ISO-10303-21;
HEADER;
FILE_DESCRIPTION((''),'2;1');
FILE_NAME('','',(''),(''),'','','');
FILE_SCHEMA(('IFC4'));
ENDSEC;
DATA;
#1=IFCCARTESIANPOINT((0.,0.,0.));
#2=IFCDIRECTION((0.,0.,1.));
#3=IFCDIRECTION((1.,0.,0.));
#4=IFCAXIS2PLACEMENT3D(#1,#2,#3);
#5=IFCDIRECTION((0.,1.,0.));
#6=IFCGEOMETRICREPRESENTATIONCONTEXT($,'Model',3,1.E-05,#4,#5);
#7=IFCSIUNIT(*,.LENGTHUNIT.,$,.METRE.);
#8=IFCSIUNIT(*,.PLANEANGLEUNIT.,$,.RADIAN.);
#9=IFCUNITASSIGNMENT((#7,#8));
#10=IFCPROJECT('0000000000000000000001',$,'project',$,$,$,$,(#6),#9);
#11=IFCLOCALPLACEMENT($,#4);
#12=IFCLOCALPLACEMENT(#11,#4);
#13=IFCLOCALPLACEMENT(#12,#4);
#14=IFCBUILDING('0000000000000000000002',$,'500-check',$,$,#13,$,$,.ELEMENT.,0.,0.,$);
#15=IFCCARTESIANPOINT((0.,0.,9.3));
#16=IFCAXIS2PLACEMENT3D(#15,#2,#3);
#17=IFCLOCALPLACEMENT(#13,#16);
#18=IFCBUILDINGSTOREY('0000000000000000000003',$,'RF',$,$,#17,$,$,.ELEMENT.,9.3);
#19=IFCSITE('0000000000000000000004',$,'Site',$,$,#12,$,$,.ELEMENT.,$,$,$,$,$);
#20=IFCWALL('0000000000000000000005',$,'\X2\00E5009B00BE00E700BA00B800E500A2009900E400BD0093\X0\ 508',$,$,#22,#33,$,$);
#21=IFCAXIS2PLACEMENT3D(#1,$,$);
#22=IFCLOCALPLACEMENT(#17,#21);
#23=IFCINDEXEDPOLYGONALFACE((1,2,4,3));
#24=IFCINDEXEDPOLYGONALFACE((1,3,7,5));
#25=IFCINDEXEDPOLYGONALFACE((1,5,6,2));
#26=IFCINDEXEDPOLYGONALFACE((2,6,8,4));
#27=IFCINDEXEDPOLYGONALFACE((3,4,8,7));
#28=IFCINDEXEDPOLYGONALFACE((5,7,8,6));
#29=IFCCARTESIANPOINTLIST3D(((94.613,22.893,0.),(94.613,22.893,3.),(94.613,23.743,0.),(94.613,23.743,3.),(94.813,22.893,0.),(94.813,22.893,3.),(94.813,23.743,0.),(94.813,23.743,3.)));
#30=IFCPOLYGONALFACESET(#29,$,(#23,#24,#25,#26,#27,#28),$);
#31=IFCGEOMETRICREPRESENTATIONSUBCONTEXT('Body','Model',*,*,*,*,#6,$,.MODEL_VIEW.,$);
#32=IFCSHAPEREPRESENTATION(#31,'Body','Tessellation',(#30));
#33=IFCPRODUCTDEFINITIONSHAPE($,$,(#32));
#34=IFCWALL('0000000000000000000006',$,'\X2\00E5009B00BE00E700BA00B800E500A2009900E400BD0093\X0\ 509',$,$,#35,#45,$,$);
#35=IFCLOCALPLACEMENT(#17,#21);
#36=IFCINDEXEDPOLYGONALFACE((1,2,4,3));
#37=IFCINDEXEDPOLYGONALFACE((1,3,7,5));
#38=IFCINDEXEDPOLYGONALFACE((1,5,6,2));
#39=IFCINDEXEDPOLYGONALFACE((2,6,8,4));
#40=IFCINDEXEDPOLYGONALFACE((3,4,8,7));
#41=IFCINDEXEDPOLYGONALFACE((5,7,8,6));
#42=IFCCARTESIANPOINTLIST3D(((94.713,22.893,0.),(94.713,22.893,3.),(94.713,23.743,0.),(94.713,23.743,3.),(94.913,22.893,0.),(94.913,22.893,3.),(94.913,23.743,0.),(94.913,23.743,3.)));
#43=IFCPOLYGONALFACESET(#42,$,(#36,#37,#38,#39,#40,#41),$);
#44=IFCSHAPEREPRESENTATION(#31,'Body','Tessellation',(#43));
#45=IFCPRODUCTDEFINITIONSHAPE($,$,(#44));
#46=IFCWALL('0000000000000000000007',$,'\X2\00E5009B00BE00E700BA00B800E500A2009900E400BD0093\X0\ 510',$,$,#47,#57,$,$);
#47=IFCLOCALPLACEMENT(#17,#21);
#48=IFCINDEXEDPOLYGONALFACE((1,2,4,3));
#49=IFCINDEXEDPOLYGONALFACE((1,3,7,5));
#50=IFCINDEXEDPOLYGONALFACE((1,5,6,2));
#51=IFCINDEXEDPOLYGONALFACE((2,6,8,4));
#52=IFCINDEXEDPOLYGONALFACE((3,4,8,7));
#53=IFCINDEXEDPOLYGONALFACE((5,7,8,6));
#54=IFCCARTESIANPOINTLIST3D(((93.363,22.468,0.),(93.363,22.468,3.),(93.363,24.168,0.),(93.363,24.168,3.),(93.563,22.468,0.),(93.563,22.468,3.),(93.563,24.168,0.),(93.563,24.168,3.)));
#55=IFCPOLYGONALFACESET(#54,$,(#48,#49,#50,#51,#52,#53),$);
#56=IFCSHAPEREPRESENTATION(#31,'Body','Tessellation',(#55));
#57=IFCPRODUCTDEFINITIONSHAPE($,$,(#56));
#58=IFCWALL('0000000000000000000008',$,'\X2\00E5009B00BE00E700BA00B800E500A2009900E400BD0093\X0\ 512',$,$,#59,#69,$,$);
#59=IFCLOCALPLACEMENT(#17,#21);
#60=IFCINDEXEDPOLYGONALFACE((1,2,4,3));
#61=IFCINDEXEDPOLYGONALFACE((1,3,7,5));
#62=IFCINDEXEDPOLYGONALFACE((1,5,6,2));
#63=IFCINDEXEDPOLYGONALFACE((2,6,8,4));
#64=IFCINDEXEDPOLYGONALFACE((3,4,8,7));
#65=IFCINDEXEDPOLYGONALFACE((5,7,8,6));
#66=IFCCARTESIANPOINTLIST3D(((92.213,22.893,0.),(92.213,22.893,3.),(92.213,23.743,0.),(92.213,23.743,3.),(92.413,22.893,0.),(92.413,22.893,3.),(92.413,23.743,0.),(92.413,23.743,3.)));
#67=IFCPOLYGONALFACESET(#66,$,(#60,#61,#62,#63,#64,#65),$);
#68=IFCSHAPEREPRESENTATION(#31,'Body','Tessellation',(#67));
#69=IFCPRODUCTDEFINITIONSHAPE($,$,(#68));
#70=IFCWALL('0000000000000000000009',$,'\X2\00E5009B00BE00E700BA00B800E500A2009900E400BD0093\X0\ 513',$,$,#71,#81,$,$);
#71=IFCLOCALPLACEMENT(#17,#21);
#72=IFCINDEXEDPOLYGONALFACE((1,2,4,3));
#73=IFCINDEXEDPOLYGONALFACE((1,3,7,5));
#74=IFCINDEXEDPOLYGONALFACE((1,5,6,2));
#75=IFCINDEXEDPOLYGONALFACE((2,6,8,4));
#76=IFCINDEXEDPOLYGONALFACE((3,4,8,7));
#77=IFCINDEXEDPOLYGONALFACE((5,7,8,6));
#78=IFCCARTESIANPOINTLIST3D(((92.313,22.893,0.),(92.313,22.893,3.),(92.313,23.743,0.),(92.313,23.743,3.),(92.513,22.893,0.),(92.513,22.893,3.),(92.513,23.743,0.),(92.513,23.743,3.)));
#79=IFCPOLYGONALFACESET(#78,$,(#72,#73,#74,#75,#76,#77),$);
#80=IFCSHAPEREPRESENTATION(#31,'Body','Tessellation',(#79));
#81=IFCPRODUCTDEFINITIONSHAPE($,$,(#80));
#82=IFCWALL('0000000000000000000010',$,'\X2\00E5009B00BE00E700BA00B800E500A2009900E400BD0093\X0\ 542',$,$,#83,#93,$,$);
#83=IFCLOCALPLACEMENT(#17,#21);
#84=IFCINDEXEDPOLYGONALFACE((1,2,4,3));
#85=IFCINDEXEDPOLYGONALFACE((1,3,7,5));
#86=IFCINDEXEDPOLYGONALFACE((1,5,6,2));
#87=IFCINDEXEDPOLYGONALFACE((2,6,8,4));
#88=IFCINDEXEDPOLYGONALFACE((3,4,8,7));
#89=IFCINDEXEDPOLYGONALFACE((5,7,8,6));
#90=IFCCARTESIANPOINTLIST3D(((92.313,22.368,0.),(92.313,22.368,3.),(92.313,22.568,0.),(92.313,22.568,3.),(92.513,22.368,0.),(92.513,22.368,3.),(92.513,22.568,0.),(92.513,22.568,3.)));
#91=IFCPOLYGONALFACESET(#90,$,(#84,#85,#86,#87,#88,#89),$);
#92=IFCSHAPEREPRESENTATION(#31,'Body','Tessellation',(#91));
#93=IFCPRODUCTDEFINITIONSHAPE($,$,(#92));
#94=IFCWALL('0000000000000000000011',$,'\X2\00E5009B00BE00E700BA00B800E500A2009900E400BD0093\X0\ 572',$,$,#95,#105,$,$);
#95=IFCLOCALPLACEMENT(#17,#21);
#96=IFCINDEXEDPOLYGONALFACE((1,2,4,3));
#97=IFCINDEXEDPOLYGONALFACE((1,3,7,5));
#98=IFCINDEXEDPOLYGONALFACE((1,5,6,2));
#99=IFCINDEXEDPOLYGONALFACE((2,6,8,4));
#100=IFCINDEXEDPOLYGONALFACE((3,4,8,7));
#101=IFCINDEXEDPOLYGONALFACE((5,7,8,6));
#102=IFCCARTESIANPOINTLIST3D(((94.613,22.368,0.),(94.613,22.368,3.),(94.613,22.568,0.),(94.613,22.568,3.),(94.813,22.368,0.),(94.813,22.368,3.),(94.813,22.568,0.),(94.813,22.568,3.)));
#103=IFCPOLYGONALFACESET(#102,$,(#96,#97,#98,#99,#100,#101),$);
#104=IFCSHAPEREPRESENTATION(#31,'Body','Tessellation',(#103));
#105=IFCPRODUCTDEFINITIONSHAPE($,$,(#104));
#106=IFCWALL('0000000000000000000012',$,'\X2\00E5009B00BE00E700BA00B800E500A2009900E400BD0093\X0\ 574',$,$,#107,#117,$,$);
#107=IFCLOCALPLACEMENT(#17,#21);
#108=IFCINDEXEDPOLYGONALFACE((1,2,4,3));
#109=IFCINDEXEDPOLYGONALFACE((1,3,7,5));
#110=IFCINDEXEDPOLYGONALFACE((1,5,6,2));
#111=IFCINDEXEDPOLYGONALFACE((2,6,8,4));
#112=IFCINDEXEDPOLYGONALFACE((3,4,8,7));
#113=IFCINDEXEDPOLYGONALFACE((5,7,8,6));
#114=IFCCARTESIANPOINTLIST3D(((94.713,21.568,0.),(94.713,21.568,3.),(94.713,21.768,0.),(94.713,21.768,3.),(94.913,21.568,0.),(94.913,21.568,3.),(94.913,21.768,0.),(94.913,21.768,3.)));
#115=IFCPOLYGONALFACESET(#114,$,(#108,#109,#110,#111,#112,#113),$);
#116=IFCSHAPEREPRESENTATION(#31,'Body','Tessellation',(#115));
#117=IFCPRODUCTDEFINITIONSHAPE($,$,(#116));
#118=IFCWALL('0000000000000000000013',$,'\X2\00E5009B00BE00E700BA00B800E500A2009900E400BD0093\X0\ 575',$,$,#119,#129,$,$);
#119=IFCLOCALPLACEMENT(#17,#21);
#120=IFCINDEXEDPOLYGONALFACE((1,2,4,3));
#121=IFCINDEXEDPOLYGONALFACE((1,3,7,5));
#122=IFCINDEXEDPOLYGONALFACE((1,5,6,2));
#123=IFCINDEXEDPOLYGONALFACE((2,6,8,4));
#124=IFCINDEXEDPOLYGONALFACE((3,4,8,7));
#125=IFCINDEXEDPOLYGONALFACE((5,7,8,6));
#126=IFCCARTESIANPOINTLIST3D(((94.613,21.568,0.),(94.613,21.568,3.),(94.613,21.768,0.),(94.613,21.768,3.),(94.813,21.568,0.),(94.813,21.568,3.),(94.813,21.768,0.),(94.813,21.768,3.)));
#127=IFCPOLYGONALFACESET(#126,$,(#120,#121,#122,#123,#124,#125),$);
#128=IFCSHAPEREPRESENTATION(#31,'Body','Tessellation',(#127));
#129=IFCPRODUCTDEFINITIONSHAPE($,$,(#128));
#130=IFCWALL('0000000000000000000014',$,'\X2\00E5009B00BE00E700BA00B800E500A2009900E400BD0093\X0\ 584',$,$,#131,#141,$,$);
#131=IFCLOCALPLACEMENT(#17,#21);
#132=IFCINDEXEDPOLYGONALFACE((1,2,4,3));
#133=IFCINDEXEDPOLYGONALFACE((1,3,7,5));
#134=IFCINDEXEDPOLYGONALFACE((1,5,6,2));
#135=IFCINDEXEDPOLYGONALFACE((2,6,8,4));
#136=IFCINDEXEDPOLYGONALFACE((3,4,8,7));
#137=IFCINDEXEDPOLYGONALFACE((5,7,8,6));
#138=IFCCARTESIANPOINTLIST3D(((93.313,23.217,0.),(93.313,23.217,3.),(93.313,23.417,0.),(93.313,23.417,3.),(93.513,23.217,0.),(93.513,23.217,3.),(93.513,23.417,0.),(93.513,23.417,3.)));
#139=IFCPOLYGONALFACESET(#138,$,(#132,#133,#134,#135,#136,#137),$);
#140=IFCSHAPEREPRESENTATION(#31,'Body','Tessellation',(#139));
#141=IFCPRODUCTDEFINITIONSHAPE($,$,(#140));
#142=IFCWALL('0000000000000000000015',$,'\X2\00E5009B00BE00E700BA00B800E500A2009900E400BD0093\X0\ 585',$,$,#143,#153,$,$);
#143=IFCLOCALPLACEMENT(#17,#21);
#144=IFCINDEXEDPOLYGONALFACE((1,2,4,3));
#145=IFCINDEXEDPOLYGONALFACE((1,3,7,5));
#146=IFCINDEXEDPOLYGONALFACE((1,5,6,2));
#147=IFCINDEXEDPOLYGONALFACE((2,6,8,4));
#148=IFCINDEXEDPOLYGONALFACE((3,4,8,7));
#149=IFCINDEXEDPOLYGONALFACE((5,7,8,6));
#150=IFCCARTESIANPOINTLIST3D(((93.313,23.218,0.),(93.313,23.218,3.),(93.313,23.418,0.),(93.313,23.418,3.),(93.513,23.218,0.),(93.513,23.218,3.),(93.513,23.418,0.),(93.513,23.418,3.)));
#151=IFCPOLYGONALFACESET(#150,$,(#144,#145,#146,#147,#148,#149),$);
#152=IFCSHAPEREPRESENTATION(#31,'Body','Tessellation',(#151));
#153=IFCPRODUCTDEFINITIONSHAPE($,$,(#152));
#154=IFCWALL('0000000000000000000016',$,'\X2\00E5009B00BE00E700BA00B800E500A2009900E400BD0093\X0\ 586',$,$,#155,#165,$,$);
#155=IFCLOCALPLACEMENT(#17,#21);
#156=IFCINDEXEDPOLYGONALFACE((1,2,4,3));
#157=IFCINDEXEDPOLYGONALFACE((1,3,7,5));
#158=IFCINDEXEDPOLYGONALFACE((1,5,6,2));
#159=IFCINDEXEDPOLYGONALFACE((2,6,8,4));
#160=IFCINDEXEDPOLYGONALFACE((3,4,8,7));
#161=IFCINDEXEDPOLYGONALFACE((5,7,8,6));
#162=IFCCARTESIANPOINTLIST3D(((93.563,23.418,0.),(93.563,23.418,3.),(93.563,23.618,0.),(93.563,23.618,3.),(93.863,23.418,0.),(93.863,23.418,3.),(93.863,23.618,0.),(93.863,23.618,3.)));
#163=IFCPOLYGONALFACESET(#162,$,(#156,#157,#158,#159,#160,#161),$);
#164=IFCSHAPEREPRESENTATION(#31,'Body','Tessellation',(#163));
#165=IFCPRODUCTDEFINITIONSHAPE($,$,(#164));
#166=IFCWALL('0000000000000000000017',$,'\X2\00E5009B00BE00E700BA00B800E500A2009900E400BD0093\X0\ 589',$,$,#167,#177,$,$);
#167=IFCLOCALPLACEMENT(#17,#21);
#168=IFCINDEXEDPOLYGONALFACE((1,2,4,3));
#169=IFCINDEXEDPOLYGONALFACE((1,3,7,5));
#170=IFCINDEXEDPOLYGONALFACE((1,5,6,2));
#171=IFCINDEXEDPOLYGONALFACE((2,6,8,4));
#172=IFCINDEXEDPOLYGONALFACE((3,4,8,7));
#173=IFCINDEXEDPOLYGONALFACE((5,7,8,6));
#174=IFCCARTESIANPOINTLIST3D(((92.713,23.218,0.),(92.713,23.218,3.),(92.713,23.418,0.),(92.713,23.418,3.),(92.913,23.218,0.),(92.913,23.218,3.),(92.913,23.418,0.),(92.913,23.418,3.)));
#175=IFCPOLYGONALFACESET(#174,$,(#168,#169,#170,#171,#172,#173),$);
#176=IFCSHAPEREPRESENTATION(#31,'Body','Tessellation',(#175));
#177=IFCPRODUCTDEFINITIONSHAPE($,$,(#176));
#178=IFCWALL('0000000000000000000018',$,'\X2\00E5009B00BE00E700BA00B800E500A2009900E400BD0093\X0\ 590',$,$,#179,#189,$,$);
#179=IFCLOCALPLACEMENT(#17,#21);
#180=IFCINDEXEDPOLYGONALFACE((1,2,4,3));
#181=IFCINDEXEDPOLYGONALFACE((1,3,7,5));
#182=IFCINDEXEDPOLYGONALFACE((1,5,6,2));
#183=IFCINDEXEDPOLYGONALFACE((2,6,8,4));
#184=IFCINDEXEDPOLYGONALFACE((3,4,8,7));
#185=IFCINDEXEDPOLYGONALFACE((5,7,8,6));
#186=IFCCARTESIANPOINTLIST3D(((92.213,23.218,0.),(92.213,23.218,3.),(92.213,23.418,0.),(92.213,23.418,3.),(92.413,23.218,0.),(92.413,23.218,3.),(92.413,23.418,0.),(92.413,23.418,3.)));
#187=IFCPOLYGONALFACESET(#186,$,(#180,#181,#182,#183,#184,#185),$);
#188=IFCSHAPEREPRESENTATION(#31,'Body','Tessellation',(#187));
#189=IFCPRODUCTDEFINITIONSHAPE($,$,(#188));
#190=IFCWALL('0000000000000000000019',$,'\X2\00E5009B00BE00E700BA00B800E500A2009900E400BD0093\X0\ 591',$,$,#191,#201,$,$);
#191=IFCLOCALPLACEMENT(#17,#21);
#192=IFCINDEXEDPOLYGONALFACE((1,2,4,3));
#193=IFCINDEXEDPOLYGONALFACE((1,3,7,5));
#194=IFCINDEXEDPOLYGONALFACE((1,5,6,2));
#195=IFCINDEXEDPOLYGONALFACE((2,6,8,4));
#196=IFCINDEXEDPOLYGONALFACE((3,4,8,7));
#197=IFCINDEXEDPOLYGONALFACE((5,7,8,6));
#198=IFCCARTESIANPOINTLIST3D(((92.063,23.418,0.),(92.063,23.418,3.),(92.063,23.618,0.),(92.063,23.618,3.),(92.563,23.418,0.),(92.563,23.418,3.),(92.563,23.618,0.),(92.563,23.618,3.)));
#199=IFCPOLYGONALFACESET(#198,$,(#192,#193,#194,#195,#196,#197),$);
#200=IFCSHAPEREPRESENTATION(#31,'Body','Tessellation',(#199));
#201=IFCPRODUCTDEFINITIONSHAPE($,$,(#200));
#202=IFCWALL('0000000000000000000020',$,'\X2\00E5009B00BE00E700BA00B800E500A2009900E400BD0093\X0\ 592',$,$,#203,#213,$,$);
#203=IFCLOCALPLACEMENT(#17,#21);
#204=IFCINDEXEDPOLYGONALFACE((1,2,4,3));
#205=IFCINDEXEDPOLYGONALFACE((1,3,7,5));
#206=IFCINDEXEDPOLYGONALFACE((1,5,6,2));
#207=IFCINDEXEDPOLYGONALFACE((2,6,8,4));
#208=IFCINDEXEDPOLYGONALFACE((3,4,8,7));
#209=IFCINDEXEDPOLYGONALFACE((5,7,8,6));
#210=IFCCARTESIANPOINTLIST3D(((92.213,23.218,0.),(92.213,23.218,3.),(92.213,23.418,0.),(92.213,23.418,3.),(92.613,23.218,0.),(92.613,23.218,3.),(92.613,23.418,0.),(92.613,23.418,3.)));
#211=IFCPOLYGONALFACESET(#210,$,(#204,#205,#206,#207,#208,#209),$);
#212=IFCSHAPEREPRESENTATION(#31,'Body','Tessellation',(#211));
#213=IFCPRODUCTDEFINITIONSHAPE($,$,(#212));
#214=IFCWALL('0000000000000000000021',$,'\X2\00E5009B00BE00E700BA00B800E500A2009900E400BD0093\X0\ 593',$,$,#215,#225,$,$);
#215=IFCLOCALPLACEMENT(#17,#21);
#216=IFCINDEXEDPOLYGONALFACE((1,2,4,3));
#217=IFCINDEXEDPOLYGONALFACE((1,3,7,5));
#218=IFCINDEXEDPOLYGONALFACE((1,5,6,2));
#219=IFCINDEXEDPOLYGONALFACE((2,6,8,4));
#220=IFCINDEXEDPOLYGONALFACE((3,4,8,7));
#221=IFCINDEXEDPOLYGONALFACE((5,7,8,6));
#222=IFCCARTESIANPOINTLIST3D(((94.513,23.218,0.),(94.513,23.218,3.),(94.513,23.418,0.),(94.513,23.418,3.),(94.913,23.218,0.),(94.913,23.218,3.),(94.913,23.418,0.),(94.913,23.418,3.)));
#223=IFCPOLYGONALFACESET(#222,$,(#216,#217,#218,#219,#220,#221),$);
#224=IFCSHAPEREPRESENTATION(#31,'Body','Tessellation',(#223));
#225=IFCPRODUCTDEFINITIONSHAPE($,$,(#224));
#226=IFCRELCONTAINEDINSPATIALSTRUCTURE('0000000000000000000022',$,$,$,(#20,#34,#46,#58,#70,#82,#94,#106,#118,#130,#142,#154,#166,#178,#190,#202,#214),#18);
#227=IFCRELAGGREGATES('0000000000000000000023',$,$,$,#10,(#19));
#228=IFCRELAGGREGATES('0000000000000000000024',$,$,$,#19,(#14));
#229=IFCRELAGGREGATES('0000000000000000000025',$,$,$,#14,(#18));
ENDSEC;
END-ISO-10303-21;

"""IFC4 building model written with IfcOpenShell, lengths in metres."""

from ifc_helpers import new_model, si_unit, direction, frame, frame_2d, origin_with_axes, place, context, subcontext, project, spatial, rectangle, extrude, element, save


model = new_model("IFC4")

# Units and contexts
model_context = context("Model", 3, precision=1e-05, world=origin_with_axes(), true_north=direction((0.0, 1.0, 0.0)))
body_context = subcontext(model_context, "Body", "Model", "MODEL_VIEW")
ifc_project = project(units=[si_unit("LENGTHUNIT", "METRE"), si_unit("PLANEANGLEUNIT", "RADIAN")], contexts=[model_context])

# Site, building, storey
placement = place(None, origin_with_axes())
site_placement = place(placement, origin_with_axes())
site = spatial("IfcSite", under=ifc_project, at=site_placement, Name="Site", CompositionType="ELEMENT")
building_placement = place(site_placement, origin_with_axes())
building = spatial("IfcBuilding", under=site, at=building_placement, Name="500-check", CompositionType="ELEMENT", ElevationOfRefHeight=0.0, ElevationOfTerrain=0.0)
storey_placement = place(building_placement, frame((0.0, 0.0, 9.3), z_axis=(0.0, 0.0, 1.0), x_axis=(1.0, 0.0, 0.0)))
storey = spatial("IfcBuildingStorey", under=building, at=storey_placement, Name="RF", CompositionType="ELEMENT", Elevation=9.3)

# Walls
for number, where, z_axis, x_axis, name in (
    (1, (94.713, 23.318, 0.0), (0.0, 0.0, 1.0), (0.0, -1.0, 0.0), "å\u009b¾çº¸å¢\u0099ä½\u0093 508"),
    (2, (94.813, 23.318, 0.0), (0.0, 0.0, 1.0), (0.0, -1.0, 0.0), "å\u009b¾çº¸å¢\u0099ä½\u0093 509"),
):
    element("IfcWall", number, at=place(storey_placement, frame(where, z_axis=z_axis, x_axis=x_axis)), inside=storey, Name=name, context=body_context, shape_type="SweptSolid", body=[
        extrude(rectangle(XDim=0.85, YDim=0.2, at=frame_2d((0.0, 0.0), x_axis=(1.0, 0.0, 0.0))), frame((0.0, 0.0, 0.0), z_axis=(0.0, 0.0, 1.0)), (0.0, 0.0, 1.0), 3.0),
    ])
wall_1_placement = place(storey_placement, frame((93.463, 23.318, 0.0), z_axis=(0.0, 0.0, 1.0), x_axis=(0.0, -1.0, 0.0)))
element("IfcWall", 3, at=wall_1_placement, inside=storey, Name="å\u009b¾çº¸å¢\u0099ä½\u0093 510", context=body_context, shape_type="SweptSolid", body=[
    extrude(rectangle(XDim=1.7, YDim=0.2, at=frame_2d((0.0, 0.0), x_axis=(1.0, 0.0, 0.0))), frame((0.0, 0.0, 0.0), z_axis=(0.0, 0.0, 1.0)), (0.0, 0.0, 1.0), 3.0),
])
for number, where, z_axis, x_axis, name in (
    (4, (92.313, 23.318, 0.0), (0.0, 0.0, 1.0), (0.0, -1.0, 0.0), "å\u009b¾çº¸å¢\u0099ä½\u0093 512"),
    (5, (92.413, 23.318, 0.0), (0.0, 0.0, 1.0), (0.0, -1.0, 0.0), "å\u009b¾çº¸å¢\u0099ä½\u0093 513"),
):
    element("IfcWall", number, at=place(storey_placement, frame(where, z_axis=z_axis, x_axis=x_axis)), inside=storey, Name=name, context=body_context, shape_type="SweptSolid", body=[
        extrude(rectangle(XDim=0.85, YDim=0.2, at=frame_2d((0.0, 0.0), x_axis=(1.0, 0.0, 0.0))), frame((0.0, 0.0, 0.0), z_axis=(0.0, 0.0, 1.0)), (0.0, 0.0, 1.0), 3.0),
    ])
for number, where, z_axis, x_axis, name in (
    (6, (92.413, 22.468, 0.0), (0.0, 0.0, 1.0), (-1.0, 0.0, 0.0), "å\u009b¾çº¸å¢\u0099ä½\u0093 542"),
    (7, (94.713, 22.468, 0.0), (0.0, 0.0, 1.0), (1.0, 0.0, 0.0), "å\u009b¾çº¸å¢\u0099ä½\u0093 572"),
    (8, (94.813, 21.668, 0.0), (0.0, 0.0, 1.0), (0.0, -1.0, 0.0), "å\u009b¾çº¸å¢\u0099ä½\u0093 574"),
    (9, (94.713, 21.668, 0.0), (0.0, 0.0, 1.0), (0.0, -1.0, 0.0), "å\u009b¾çº¸å¢\u0099ä½\u0093 575"),
    (10, (93.413, 23.317, 0.0), (0.0, 0.0, 1.0), (1.0, 0.0, 0.0), "å\u009b¾çº¸å¢\u0099ä½\u0093 584"),
    (11, (93.413, 23.318, 0.0), (0.0, 0.0, 1.0), (1.0, 0.0, 0.0), "å\u009b¾çº¸å¢\u0099ä½\u0093 585"),
):
    element("IfcWall", number, at=place(storey_placement, frame(where, z_axis=z_axis, x_axis=x_axis)), inside=storey, Name=name, context=body_context, shape_type="SweptSolid", body=[
        extrude(rectangle(XDim=0.2, YDim=0.2, at=frame_2d((0.0, 0.0), x_axis=(1.0, 0.0, 0.0))), frame((0.0, 0.0, 0.0), z_axis=(0.0, 0.0, 1.0)), (0.0, 0.0, 1.0), 3.0),
    ])
wall_2_placement = place(storey_placement, frame((93.713, 23.518, 0.0), z_axis=(0.0, 0.0, 1.0), x_axis=(-1.0, 0.0, 0.0)))
element("IfcWall", 12, at=wall_2_placement, inside=storey, Name="å\u009b¾çº¸å¢\u0099ä½\u0093 586", context=body_context, shape_type="SweptSolid", body=[
    extrude(rectangle(XDim=0.3, YDim=0.2, at=frame_2d((0.0, 0.0), x_axis=(1.0, 0.0, 0.0))), frame((0.0, 0.0, 0.0), z_axis=(0.0, 0.0, 1.0)), (0.0, 0.0, 1.0), 3.0),
])
for number, where, z_axis, x_axis, name in (
    (13, (92.813, 23.318, 0.0), (0.0, 0.0, 1.0), (0.0, 1.0, 0.0), "å\u009b¾çº¸å¢\u0099ä½\u0093 589"),
    (14, (92.313, 23.318, 0.0), (0.0, 0.0, 1.0), (0.0, 1.0, 0.0), "å\u009b¾çº¸å¢\u0099ä½\u0093 590"),
):
    element("IfcWall", number, at=place(storey_placement, frame(where, z_axis=z_axis, x_axis=x_axis)), inside=storey, Name=name, context=body_context, shape_type="SweptSolid", body=[
        extrude(rectangle(XDim=0.2, YDim=0.2, at=frame_2d((0.0, 0.0), x_axis=(1.0, 0.0, 0.0))), frame((0.0, 0.0, 0.0), z_axis=(0.0, 0.0, 1.0)), (0.0, 0.0, 1.0), 3.0),
    ])
wall_3_placement = place(storey_placement, frame((92.313, 23.518, 0.0), z_axis=(0.0, 0.0, 1.0), x_axis=(1.0, 0.0, 0.0)))
element("IfcWall", 15, at=wall_3_placement, inside=storey, Name="å\u009b¾çº¸å¢\u0099ä½\u0093 591", context=body_context, shape_type="SweptSolid", body=[
    extrude(rectangle(XDim=0.5, YDim=0.2, at=frame_2d((0.0, 0.0), x_axis=(1.0, 0.0, 0.0))), frame((0.0, 0.0, 0.0), z_axis=(0.0, 0.0, 1.0)), (0.0, 0.0, 1.0), 3.0),
])
for number, where, z_axis, x_axis, name in (
    (16, (92.413, 23.318, 0.0), (0.0, 0.0, 1.0), (1.0, 0.0, 0.0), "å\u009b¾çº¸å¢\u0099ä½\u0093 592"),
    (17, (94.713, 23.318, 0.0), (0.0, 0.0, 1.0), (-1.0, 0.0, 0.0), "å\u009b¾çº¸å¢\u0099ä½\u0093 593"),
):
    element("IfcWall", number, at=place(storey_placement, frame(where, z_axis=z_axis, x_axis=x_axis)), inside=storey, Name=name, context=body_context, shape_type="SweptSolid", body=[
        extrude(rectangle(XDim=0.4, YDim=0.2, at=frame_2d((0.0, 0.0), x_axis=(1.0, 0.0, 0.0))), frame((0.0, 0.0, 0.0), z_axis=(0.0, 0.0, 1.0)), (0.0, 0.0, 1.0), 3.0),
    ])

save(model, "model.ifc")
